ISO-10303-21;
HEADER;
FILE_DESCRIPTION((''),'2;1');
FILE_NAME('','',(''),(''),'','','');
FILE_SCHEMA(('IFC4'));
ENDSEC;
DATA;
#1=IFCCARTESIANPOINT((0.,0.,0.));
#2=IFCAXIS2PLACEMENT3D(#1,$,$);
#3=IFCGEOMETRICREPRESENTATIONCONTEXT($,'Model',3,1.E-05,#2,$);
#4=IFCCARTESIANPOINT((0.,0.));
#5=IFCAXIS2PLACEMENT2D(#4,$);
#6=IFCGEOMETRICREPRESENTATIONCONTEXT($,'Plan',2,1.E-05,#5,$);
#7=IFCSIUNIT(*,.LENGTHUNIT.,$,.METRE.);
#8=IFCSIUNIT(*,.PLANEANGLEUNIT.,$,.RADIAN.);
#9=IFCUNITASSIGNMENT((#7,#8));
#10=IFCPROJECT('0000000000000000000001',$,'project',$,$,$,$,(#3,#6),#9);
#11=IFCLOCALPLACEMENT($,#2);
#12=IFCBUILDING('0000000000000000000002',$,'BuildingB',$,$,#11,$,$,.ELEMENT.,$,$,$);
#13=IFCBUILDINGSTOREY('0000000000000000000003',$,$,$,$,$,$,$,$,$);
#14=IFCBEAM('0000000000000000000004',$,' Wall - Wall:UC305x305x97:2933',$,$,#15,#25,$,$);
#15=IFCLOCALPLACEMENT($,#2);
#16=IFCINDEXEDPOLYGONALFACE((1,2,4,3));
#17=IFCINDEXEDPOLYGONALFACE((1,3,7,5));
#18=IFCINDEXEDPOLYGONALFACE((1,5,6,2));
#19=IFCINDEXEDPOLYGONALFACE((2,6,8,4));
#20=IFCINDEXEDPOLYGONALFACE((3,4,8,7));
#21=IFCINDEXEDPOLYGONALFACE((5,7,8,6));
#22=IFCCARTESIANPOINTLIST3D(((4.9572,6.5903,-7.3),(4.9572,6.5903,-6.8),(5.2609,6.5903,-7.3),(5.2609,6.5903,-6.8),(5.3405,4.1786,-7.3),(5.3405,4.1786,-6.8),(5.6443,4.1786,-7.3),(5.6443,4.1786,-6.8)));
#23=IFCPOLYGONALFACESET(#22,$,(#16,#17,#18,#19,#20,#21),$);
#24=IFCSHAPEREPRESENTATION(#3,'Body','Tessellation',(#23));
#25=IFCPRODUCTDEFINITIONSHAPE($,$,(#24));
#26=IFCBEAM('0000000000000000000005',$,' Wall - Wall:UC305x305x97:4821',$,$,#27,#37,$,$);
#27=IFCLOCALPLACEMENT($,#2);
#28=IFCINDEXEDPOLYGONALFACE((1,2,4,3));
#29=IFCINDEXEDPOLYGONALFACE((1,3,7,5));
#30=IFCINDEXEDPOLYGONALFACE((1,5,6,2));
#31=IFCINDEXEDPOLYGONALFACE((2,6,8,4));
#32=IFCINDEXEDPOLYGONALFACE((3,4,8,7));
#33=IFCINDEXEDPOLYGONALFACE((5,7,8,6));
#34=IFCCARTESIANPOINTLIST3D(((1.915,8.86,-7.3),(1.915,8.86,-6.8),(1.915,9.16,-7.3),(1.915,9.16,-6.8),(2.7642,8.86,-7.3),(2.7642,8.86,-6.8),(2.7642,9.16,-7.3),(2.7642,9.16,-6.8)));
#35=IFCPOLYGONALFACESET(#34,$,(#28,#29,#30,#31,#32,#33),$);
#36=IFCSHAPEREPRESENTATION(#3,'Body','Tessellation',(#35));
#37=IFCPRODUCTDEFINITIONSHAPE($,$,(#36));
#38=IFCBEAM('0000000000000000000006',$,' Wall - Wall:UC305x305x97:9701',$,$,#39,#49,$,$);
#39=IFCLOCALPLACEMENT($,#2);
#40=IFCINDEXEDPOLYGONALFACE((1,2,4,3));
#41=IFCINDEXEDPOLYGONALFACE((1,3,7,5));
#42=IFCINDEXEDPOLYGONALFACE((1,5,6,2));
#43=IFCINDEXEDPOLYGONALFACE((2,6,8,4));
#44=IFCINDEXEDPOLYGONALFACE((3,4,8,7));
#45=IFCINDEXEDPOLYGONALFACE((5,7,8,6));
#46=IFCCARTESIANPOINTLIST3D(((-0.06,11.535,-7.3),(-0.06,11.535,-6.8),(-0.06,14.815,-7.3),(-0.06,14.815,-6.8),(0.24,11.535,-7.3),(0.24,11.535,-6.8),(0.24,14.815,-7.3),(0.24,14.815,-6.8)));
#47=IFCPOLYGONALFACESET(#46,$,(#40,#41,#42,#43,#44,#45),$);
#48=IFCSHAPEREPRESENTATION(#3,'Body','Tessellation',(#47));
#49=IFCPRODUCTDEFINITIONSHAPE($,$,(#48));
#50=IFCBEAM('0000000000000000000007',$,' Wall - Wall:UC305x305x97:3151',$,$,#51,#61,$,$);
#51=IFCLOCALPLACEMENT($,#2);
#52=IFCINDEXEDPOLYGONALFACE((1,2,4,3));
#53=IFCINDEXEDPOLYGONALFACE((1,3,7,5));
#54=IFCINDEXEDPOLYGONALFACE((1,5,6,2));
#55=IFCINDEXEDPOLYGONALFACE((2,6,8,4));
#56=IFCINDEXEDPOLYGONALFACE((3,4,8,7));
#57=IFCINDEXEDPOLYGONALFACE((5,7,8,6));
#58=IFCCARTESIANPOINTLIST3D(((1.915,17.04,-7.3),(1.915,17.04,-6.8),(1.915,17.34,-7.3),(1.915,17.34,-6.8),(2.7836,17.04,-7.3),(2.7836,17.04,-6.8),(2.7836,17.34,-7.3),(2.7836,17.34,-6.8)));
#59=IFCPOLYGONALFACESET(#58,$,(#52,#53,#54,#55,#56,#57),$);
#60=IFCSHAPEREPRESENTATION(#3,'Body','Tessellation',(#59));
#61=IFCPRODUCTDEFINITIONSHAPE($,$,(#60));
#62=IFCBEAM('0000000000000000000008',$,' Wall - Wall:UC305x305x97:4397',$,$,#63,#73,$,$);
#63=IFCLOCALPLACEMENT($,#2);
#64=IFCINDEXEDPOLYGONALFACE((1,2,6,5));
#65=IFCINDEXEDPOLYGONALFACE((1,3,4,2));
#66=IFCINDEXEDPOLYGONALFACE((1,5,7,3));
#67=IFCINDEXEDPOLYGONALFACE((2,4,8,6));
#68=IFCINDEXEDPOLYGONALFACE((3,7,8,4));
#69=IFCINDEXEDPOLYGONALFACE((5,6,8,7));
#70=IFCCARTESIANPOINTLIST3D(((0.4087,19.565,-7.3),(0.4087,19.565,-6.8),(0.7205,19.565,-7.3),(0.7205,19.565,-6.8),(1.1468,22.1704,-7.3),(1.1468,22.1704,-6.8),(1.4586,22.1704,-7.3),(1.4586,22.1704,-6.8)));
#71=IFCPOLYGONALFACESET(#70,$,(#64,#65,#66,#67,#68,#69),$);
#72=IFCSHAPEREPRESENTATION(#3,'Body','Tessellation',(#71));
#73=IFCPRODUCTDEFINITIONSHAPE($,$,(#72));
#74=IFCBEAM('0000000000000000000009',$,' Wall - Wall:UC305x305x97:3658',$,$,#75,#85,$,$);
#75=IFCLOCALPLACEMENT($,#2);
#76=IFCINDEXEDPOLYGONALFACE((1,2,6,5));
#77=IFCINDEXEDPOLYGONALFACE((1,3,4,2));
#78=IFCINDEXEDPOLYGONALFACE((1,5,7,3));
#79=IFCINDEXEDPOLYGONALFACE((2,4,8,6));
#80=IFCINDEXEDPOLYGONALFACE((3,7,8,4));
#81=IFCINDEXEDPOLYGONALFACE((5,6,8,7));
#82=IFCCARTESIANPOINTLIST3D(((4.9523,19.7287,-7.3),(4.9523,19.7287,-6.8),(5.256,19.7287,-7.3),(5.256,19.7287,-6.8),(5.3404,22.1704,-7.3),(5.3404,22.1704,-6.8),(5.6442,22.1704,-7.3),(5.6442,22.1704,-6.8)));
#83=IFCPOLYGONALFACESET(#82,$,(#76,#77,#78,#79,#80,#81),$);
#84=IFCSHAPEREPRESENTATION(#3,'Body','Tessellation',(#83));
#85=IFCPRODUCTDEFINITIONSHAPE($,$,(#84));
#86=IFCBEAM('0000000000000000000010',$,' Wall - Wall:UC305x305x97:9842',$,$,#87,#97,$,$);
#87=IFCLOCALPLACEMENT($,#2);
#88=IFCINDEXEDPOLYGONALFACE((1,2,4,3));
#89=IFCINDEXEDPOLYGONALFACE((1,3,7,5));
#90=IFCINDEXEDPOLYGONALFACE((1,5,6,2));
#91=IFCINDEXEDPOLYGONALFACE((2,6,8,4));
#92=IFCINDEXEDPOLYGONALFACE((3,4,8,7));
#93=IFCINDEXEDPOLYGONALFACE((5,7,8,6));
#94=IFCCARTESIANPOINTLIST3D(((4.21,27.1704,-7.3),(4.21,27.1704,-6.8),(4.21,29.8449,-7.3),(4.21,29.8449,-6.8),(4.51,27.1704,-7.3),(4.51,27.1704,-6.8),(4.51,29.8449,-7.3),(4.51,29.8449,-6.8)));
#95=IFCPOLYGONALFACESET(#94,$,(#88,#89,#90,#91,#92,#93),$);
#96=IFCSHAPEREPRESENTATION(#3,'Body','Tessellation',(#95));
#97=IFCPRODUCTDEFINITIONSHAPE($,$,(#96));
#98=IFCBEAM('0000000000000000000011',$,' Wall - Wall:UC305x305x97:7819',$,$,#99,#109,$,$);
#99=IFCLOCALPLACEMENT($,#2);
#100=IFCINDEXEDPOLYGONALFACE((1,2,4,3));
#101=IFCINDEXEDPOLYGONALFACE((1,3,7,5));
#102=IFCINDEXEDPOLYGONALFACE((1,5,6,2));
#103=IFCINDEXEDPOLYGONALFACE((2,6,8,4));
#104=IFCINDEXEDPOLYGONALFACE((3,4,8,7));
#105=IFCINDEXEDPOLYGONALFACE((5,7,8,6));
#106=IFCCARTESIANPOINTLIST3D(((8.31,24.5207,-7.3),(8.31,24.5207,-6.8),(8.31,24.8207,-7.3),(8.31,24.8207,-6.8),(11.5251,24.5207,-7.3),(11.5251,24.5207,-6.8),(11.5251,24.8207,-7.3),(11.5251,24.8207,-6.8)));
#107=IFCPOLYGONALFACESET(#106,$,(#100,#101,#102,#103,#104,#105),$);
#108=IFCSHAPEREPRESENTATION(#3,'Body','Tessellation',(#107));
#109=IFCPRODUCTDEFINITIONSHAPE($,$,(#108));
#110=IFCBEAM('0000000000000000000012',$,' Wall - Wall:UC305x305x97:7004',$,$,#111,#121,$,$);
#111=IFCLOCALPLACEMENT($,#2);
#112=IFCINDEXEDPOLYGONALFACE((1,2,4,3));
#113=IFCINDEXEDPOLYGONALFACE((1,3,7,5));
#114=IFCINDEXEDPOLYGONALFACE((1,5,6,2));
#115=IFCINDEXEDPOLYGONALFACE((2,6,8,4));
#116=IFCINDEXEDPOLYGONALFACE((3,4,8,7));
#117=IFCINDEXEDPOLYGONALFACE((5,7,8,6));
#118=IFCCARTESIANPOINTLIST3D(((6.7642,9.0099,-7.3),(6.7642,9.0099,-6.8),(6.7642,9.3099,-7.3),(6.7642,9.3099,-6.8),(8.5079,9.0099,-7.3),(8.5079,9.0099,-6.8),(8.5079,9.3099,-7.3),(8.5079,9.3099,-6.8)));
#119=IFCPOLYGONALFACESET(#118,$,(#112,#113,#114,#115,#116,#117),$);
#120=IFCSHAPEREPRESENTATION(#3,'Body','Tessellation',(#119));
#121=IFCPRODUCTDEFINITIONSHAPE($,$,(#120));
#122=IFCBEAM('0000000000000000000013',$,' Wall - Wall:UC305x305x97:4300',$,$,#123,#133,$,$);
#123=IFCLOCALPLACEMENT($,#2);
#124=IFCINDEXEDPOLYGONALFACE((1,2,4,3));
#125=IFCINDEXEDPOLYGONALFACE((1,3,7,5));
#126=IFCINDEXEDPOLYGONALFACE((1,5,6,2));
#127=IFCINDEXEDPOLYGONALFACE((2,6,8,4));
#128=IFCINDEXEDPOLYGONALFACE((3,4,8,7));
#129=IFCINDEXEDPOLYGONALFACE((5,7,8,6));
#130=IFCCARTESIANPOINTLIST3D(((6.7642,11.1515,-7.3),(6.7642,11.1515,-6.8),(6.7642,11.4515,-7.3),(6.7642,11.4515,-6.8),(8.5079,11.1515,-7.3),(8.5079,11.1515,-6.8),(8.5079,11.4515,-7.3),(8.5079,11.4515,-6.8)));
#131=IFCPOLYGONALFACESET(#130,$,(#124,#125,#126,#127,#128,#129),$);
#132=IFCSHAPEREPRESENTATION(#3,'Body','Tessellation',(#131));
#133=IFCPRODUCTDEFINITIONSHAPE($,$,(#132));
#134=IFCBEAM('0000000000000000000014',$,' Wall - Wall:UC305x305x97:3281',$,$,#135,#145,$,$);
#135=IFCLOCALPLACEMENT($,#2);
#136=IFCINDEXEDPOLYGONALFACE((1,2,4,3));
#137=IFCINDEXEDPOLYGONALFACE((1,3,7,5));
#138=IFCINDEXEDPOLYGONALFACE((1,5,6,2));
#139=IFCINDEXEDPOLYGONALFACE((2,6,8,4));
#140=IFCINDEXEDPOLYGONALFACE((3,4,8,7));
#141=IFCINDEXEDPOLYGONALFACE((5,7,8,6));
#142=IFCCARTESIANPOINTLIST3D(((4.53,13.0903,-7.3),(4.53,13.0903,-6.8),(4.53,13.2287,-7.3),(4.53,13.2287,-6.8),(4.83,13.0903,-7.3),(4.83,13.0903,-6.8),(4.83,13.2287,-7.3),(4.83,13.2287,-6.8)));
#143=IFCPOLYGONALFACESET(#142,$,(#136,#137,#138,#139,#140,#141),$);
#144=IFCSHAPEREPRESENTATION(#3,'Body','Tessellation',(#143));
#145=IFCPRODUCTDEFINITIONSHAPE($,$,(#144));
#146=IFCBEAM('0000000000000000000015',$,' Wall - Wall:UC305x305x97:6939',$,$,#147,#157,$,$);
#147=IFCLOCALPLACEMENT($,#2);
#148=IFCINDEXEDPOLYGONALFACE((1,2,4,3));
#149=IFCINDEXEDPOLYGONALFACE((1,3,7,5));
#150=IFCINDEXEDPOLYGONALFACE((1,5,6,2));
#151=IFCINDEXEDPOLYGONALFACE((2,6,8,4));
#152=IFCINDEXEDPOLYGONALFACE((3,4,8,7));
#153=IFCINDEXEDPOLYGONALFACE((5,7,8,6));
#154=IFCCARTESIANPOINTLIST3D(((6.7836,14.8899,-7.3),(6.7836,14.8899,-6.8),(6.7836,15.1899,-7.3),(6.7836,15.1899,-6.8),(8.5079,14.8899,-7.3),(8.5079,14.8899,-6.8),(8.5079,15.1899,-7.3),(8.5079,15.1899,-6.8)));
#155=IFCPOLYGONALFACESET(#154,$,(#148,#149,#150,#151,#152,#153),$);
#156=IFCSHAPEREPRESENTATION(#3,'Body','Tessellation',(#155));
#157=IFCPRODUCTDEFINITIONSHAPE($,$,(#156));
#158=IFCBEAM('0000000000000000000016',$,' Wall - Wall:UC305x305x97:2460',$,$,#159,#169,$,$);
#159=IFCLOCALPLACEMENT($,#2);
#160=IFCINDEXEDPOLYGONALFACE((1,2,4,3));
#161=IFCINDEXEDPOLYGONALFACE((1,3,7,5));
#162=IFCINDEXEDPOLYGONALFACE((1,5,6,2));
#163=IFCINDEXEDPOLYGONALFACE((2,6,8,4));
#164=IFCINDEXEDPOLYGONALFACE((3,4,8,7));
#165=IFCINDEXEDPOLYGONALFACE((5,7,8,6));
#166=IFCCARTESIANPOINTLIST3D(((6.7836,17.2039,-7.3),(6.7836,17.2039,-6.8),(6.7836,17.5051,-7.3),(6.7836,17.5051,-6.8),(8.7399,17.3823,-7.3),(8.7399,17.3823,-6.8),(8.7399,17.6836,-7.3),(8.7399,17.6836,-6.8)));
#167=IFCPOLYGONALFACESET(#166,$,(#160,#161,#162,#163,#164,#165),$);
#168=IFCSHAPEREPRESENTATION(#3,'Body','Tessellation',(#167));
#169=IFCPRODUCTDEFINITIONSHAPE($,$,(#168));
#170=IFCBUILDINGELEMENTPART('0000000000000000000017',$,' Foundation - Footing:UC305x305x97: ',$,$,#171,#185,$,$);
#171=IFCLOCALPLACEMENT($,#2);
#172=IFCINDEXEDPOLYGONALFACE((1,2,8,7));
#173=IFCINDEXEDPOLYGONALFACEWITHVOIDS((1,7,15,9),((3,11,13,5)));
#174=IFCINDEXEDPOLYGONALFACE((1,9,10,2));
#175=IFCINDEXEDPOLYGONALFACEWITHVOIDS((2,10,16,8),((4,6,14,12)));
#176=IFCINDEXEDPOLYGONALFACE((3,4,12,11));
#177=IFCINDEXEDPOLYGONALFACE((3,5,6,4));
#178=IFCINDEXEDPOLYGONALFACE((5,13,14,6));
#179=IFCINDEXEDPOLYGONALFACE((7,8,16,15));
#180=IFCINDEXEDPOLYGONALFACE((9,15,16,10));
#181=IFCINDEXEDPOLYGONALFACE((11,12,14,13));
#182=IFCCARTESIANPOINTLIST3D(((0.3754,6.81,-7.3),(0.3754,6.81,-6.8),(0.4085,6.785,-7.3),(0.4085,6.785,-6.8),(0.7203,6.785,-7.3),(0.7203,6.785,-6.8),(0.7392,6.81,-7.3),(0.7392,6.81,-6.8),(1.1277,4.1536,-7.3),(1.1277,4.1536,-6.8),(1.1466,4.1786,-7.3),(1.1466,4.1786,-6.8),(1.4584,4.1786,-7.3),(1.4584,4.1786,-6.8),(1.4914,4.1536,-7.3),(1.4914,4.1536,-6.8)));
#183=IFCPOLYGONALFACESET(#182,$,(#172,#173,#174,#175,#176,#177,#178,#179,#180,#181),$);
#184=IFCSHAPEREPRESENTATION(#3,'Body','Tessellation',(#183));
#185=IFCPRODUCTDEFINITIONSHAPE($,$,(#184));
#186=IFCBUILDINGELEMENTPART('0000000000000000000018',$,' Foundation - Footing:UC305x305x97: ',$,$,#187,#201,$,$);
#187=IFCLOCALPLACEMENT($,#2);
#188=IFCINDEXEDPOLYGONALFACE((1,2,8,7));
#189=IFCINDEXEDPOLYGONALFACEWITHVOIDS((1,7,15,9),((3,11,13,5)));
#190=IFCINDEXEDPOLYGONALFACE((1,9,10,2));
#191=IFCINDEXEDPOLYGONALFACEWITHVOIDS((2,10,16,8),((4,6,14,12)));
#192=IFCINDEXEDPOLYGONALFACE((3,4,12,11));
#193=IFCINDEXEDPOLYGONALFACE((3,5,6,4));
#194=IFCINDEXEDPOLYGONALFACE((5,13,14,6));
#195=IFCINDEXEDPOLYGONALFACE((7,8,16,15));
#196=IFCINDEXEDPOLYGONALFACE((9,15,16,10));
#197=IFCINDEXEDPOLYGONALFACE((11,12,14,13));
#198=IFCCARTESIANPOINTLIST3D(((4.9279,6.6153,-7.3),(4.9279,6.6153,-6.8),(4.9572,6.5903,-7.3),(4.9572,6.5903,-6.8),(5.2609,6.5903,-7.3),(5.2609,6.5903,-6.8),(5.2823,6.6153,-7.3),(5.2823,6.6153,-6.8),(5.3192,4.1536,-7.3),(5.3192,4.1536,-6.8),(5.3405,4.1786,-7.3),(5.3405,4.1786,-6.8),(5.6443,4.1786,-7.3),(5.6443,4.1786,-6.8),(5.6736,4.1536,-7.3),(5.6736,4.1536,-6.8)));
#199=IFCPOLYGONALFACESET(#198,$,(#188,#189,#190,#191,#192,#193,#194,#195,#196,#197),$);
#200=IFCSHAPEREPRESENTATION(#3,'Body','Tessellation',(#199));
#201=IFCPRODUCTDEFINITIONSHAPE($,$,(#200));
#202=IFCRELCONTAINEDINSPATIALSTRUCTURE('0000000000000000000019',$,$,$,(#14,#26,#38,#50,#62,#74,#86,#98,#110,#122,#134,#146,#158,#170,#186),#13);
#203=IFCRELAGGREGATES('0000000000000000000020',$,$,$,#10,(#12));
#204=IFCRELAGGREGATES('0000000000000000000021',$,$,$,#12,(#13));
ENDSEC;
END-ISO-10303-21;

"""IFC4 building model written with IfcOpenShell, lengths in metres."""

from ifc_helpers import new_model, si_unit, origin, origin_2d, place, context, project, spatial, polyline, outline, extrude, element, save


model = new_model("IFC4")

# Units and contexts
model_context = context("Model", 3, precision=1e-05, world=origin())
plan_context = context("Plan", 2, precision=1e-05, world=origin_2d())
ifc_project = project(units=[si_unit("LENGTHUNIT", "METRE"), si_unit("PLANEANGLEUNIT", "RADIAN")], contexts=[model_context, plan_context])

# Building, storey
building_placement = place(None, origin())
building = spatial("IfcBuilding", under=ifc_project, at=building_placement, Name="BuildingB", CompositionType="ELEMENT")
storey = spatial("IfcBuildingStorey", under=building)

# Beams
element("IfcBeam", 1, inside=storey, Name=" Wall - Wall:UC305x305x97:2933", context=model_context, shape_type="SweptSolid", body=[
    extrude(outline(polyline([(5.3405, 4.1786, -7.3), (4.9572, 6.5903, -7.3), (5.2609, 6.5903, -7.3), (5.6443, 4.1786, -7.3), (5.3405, 4.1786, -7.3)])), None, (0.0, 0.0, 1.0), 0.5),
])
element("IfcBeam", 2, inside=storey, Name=" Wall - Wall:UC305x305x97:4821", context=model_context, shape_type="SweptSolid", body=[
    extrude(outline(polyline([(1.915, 8.86, -7.3), (1.915, 9.16, -7.3), (2.7642, 9.16, -7.3), (2.7642, 8.86, -7.3), (1.915, 8.86, -7.3)])), None, (0.0, 0.0, 1.0), 0.5),
])
element("IfcBeam", 3, inside=storey, Name=" Wall - Wall:UC305x305x97:9701", context=model_context, shape_type="SweptSolid", body=[
    extrude(outline(polyline([(-0.06, 11.535, -7.3), (-0.06, 14.815, -7.3), (0.24, 14.815, -7.3), (0.24, 11.535, -7.3), (-0.06, 11.535, -7.3)])), None, (0.0, 0.0, 1.0), 0.5),
])
element("IfcBeam", 4, inside=storey, Name=" Wall - Wall:UC305x305x97:3151", context=model_context, shape_type="SweptSolid", body=[
    extrude(outline(polyline([(1.915, 17.04, -7.3), (1.915, 17.34, -7.3), (2.7836, 17.34, -7.3), (2.7836, 17.04, -7.3), (1.915, 17.04, -7.3)])), None, (0.0, 0.0, 1.0), 0.5),
])
element("IfcBeam", 5, inside=storey, Name=" Wall - Wall:UC305x305x97:4397", context=model_context, shape_type="SweptSolid", body=[
    extrude(outline(polyline([(0.4087, 19.565, -7.3), (1.1468, 22.1704, -7.3), (1.4586, 22.1704, -7.3), (0.7205, 19.565, -7.3), (0.4087, 19.565, -7.3)])), None, (0.0, 0.0, 1.0), 0.5),
])
element("IfcBeam", 6, inside=storey, Name=" Wall - Wall:UC305x305x97:3658", context=model_context, shape_type="SweptSolid", body=[
    extrude(outline(polyline([(5.256, 19.7287, -7.3), (4.9523, 19.7287, -7.3), (5.3404, 22.1704, -7.3), (5.6442, 22.1704, -7.3), (5.256, 19.7287, -7.3)])), None, (0.0, 0.0, 1.0), 0.5),
])
element("IfcBeam", 7, inside=storey, Name=" Wall - Wall:UC305x305x97:9842", context=model_context, shape_type="SweptSolid", body=[
    extrude(outline(polyline([(4.51, 27.1704, -7.3), (4.21, 27.1704, -7.3), (4.21, 29.8449, -7.3), (4.51, 29.8449, -7.3), (4.51, 27.1704, -7.3)])), None, (0.0, 0.0, 1.0), 0.5),
])
element("IfcBeam", 8, inside=storey, Name=" Wall - Wall:UC305x305x97:7819", context=model_context, shape_type="SweptSolid", body=[
    extrude(outline(polyline([(8.31, 24.5207, -7.3), (8.31, 24.8207, -7.3), (11.5251, 24.8207, -7.3), (11.5251, 24.5207, -7.3), (8.31, 24.5207, -7.3)])), None, (0.0, 0.0, 1.0), 0.5),
])
element("IfcBeam", 9, inside=storey, Name=" Wall - Wall:UC305x305x97:7004", context=model_context, shape_type="SweptSolid", body=[
    extrude(outline(polyline([(6.7642, 9.0099, -7.3), (6.7642, 9.3099, -7.3), (8.5079, 9.3099, -7.3), (8.5079, 9.0099, -7.3), (6.7642, 9.0099, -7.3)])), None, (0.0, 0.0, 1.0), 0.5),
])
element("IfcBeam", 10, inside=storey, Name=" Wall - Wall:UC305x305x97:4300", context=model_context, shape_type="SweptSolid", body=[
    extrude(outline(polyline([(6.7642, 11.1515, -7.3), (6.7642, 11.4515, -7.3), (8.5079, 11.4515, -7.3), (8.5079, 11.1515, -7.3), (6.7642, 11.1515, -7.3)])), None, (0.0, 0.0, 1.0), 0.5),
])
element("IfcBeam", 11, inside=storey, Name=" Wall - Wall:UC305x305x97:3281", context=model_context, shape_type="SweptSolid", body=[
    extrude(outline(polyline([(4.53, 13.0903, -7.3), (4.53, 13.2287, -7.3), (4.83, 13.2287, -7.3), (4.83, 13.0903, -7.3), (4.53, 13.0903, -7.3)])), None, (0.0, 0.0, 1.0), 0.5),
])
element("IfcBeam", 12, inside=storey, Name=" Wall - Wall:UC305x305x97:6939", context=model_context, shape_type="SweptSolid", body=[
    extrude(outline(polyline([(6.7836, 14.8899, -7.3), (6.7836, 15.1899, -7.3), (8.5079, 15.1899, -7.3), (8.5079, 14.8899, -7.3), (6.7836, 14.8899, -7.3)])), None, (0.0, 0.0, 1.0), 0.5),
])
element("IfcBeam", 13, inside=storey, Name=" Wall - Wall:UC305x305x97:2460", context=model_context, shape_type="SweptSolid", body=[
    extrude(outline(polyline([(6.7836, 17.2039, -7.3), (6.7836, 17.5051, -7.3), (8.7399, 17.6836, -7.3), (8.7399, 17.3823, -7.3), (6.7836, 17.2039, -7.3)])), None, (0.0, 0.0, 1.0), 0.5),
])

# Building element parts, openings
building_element_part_1 = element("IfcBuildingElementPart", 14, inside=storey, Name=" Foundation - Footing:UC305x305x97: ", context=model_context, shape_type="SweptSolid", body=[
    extrude(outline(polyline([(1.1277, 4.1536, -7.3), (0.3754, 6.81, -7.3), (0.7392, 6.81, -7.3), (1.4914, 4.1536, -7.3), (1.1277, 4.1536, -7.3)])), None, (0.0, 0.0, 1.0), 0.5),
])
element("IfcOpeningElement", 15, inside=storey, cuts=building_element_part_1, context=model_context, shape_type="SweptSolid", body=[
    extrude(outline(polyline([(1.1466, 4.1786, -7.3), (0.4085, 6.785, -7.3), (0.7203, 6.785, -7.3), (1.4584, 4.1786, -7.3), (1.1466, 4.1786, -7.3)])), None, (0.0, 0.0, 1.0), 0.5),
])
building_element_part_2 = element("IfcBuildingElementPart", 16, inside=storey, Name=" Foundation - Footing:UC305x305x97: ", context=model_context, shape_type="SweptSolid", body=[
    extrude(outline(polyline([(5.3192, 4.1536, -7.3), (4.9279, 6.6153, -7.3), (5.2823, 6.6153, -7.3), (5.6736, 4.1536, -7.3), (5.3192, 4.1536, -7.3)])), None, (0.0, 0.0, 1.0), 0.5),
])
element("IfcOpeningElement", 17, inside=storey, cuts=building_element_part_2, context=model_context, shape_type="SweptSolid", body=[
    extrude(outline(polyline([(5.3405, 4.1786, -7.3), (4.9572, 6.5903, -7.3), (5.2609, 6.5903, -7.3), (5.6443, 4.1786, -7.3), (5.3405, 4.1786, -7.3)])), None, (0.0, 0.0, 1.0), 0.5),
])

save(model, "model.ifc")
